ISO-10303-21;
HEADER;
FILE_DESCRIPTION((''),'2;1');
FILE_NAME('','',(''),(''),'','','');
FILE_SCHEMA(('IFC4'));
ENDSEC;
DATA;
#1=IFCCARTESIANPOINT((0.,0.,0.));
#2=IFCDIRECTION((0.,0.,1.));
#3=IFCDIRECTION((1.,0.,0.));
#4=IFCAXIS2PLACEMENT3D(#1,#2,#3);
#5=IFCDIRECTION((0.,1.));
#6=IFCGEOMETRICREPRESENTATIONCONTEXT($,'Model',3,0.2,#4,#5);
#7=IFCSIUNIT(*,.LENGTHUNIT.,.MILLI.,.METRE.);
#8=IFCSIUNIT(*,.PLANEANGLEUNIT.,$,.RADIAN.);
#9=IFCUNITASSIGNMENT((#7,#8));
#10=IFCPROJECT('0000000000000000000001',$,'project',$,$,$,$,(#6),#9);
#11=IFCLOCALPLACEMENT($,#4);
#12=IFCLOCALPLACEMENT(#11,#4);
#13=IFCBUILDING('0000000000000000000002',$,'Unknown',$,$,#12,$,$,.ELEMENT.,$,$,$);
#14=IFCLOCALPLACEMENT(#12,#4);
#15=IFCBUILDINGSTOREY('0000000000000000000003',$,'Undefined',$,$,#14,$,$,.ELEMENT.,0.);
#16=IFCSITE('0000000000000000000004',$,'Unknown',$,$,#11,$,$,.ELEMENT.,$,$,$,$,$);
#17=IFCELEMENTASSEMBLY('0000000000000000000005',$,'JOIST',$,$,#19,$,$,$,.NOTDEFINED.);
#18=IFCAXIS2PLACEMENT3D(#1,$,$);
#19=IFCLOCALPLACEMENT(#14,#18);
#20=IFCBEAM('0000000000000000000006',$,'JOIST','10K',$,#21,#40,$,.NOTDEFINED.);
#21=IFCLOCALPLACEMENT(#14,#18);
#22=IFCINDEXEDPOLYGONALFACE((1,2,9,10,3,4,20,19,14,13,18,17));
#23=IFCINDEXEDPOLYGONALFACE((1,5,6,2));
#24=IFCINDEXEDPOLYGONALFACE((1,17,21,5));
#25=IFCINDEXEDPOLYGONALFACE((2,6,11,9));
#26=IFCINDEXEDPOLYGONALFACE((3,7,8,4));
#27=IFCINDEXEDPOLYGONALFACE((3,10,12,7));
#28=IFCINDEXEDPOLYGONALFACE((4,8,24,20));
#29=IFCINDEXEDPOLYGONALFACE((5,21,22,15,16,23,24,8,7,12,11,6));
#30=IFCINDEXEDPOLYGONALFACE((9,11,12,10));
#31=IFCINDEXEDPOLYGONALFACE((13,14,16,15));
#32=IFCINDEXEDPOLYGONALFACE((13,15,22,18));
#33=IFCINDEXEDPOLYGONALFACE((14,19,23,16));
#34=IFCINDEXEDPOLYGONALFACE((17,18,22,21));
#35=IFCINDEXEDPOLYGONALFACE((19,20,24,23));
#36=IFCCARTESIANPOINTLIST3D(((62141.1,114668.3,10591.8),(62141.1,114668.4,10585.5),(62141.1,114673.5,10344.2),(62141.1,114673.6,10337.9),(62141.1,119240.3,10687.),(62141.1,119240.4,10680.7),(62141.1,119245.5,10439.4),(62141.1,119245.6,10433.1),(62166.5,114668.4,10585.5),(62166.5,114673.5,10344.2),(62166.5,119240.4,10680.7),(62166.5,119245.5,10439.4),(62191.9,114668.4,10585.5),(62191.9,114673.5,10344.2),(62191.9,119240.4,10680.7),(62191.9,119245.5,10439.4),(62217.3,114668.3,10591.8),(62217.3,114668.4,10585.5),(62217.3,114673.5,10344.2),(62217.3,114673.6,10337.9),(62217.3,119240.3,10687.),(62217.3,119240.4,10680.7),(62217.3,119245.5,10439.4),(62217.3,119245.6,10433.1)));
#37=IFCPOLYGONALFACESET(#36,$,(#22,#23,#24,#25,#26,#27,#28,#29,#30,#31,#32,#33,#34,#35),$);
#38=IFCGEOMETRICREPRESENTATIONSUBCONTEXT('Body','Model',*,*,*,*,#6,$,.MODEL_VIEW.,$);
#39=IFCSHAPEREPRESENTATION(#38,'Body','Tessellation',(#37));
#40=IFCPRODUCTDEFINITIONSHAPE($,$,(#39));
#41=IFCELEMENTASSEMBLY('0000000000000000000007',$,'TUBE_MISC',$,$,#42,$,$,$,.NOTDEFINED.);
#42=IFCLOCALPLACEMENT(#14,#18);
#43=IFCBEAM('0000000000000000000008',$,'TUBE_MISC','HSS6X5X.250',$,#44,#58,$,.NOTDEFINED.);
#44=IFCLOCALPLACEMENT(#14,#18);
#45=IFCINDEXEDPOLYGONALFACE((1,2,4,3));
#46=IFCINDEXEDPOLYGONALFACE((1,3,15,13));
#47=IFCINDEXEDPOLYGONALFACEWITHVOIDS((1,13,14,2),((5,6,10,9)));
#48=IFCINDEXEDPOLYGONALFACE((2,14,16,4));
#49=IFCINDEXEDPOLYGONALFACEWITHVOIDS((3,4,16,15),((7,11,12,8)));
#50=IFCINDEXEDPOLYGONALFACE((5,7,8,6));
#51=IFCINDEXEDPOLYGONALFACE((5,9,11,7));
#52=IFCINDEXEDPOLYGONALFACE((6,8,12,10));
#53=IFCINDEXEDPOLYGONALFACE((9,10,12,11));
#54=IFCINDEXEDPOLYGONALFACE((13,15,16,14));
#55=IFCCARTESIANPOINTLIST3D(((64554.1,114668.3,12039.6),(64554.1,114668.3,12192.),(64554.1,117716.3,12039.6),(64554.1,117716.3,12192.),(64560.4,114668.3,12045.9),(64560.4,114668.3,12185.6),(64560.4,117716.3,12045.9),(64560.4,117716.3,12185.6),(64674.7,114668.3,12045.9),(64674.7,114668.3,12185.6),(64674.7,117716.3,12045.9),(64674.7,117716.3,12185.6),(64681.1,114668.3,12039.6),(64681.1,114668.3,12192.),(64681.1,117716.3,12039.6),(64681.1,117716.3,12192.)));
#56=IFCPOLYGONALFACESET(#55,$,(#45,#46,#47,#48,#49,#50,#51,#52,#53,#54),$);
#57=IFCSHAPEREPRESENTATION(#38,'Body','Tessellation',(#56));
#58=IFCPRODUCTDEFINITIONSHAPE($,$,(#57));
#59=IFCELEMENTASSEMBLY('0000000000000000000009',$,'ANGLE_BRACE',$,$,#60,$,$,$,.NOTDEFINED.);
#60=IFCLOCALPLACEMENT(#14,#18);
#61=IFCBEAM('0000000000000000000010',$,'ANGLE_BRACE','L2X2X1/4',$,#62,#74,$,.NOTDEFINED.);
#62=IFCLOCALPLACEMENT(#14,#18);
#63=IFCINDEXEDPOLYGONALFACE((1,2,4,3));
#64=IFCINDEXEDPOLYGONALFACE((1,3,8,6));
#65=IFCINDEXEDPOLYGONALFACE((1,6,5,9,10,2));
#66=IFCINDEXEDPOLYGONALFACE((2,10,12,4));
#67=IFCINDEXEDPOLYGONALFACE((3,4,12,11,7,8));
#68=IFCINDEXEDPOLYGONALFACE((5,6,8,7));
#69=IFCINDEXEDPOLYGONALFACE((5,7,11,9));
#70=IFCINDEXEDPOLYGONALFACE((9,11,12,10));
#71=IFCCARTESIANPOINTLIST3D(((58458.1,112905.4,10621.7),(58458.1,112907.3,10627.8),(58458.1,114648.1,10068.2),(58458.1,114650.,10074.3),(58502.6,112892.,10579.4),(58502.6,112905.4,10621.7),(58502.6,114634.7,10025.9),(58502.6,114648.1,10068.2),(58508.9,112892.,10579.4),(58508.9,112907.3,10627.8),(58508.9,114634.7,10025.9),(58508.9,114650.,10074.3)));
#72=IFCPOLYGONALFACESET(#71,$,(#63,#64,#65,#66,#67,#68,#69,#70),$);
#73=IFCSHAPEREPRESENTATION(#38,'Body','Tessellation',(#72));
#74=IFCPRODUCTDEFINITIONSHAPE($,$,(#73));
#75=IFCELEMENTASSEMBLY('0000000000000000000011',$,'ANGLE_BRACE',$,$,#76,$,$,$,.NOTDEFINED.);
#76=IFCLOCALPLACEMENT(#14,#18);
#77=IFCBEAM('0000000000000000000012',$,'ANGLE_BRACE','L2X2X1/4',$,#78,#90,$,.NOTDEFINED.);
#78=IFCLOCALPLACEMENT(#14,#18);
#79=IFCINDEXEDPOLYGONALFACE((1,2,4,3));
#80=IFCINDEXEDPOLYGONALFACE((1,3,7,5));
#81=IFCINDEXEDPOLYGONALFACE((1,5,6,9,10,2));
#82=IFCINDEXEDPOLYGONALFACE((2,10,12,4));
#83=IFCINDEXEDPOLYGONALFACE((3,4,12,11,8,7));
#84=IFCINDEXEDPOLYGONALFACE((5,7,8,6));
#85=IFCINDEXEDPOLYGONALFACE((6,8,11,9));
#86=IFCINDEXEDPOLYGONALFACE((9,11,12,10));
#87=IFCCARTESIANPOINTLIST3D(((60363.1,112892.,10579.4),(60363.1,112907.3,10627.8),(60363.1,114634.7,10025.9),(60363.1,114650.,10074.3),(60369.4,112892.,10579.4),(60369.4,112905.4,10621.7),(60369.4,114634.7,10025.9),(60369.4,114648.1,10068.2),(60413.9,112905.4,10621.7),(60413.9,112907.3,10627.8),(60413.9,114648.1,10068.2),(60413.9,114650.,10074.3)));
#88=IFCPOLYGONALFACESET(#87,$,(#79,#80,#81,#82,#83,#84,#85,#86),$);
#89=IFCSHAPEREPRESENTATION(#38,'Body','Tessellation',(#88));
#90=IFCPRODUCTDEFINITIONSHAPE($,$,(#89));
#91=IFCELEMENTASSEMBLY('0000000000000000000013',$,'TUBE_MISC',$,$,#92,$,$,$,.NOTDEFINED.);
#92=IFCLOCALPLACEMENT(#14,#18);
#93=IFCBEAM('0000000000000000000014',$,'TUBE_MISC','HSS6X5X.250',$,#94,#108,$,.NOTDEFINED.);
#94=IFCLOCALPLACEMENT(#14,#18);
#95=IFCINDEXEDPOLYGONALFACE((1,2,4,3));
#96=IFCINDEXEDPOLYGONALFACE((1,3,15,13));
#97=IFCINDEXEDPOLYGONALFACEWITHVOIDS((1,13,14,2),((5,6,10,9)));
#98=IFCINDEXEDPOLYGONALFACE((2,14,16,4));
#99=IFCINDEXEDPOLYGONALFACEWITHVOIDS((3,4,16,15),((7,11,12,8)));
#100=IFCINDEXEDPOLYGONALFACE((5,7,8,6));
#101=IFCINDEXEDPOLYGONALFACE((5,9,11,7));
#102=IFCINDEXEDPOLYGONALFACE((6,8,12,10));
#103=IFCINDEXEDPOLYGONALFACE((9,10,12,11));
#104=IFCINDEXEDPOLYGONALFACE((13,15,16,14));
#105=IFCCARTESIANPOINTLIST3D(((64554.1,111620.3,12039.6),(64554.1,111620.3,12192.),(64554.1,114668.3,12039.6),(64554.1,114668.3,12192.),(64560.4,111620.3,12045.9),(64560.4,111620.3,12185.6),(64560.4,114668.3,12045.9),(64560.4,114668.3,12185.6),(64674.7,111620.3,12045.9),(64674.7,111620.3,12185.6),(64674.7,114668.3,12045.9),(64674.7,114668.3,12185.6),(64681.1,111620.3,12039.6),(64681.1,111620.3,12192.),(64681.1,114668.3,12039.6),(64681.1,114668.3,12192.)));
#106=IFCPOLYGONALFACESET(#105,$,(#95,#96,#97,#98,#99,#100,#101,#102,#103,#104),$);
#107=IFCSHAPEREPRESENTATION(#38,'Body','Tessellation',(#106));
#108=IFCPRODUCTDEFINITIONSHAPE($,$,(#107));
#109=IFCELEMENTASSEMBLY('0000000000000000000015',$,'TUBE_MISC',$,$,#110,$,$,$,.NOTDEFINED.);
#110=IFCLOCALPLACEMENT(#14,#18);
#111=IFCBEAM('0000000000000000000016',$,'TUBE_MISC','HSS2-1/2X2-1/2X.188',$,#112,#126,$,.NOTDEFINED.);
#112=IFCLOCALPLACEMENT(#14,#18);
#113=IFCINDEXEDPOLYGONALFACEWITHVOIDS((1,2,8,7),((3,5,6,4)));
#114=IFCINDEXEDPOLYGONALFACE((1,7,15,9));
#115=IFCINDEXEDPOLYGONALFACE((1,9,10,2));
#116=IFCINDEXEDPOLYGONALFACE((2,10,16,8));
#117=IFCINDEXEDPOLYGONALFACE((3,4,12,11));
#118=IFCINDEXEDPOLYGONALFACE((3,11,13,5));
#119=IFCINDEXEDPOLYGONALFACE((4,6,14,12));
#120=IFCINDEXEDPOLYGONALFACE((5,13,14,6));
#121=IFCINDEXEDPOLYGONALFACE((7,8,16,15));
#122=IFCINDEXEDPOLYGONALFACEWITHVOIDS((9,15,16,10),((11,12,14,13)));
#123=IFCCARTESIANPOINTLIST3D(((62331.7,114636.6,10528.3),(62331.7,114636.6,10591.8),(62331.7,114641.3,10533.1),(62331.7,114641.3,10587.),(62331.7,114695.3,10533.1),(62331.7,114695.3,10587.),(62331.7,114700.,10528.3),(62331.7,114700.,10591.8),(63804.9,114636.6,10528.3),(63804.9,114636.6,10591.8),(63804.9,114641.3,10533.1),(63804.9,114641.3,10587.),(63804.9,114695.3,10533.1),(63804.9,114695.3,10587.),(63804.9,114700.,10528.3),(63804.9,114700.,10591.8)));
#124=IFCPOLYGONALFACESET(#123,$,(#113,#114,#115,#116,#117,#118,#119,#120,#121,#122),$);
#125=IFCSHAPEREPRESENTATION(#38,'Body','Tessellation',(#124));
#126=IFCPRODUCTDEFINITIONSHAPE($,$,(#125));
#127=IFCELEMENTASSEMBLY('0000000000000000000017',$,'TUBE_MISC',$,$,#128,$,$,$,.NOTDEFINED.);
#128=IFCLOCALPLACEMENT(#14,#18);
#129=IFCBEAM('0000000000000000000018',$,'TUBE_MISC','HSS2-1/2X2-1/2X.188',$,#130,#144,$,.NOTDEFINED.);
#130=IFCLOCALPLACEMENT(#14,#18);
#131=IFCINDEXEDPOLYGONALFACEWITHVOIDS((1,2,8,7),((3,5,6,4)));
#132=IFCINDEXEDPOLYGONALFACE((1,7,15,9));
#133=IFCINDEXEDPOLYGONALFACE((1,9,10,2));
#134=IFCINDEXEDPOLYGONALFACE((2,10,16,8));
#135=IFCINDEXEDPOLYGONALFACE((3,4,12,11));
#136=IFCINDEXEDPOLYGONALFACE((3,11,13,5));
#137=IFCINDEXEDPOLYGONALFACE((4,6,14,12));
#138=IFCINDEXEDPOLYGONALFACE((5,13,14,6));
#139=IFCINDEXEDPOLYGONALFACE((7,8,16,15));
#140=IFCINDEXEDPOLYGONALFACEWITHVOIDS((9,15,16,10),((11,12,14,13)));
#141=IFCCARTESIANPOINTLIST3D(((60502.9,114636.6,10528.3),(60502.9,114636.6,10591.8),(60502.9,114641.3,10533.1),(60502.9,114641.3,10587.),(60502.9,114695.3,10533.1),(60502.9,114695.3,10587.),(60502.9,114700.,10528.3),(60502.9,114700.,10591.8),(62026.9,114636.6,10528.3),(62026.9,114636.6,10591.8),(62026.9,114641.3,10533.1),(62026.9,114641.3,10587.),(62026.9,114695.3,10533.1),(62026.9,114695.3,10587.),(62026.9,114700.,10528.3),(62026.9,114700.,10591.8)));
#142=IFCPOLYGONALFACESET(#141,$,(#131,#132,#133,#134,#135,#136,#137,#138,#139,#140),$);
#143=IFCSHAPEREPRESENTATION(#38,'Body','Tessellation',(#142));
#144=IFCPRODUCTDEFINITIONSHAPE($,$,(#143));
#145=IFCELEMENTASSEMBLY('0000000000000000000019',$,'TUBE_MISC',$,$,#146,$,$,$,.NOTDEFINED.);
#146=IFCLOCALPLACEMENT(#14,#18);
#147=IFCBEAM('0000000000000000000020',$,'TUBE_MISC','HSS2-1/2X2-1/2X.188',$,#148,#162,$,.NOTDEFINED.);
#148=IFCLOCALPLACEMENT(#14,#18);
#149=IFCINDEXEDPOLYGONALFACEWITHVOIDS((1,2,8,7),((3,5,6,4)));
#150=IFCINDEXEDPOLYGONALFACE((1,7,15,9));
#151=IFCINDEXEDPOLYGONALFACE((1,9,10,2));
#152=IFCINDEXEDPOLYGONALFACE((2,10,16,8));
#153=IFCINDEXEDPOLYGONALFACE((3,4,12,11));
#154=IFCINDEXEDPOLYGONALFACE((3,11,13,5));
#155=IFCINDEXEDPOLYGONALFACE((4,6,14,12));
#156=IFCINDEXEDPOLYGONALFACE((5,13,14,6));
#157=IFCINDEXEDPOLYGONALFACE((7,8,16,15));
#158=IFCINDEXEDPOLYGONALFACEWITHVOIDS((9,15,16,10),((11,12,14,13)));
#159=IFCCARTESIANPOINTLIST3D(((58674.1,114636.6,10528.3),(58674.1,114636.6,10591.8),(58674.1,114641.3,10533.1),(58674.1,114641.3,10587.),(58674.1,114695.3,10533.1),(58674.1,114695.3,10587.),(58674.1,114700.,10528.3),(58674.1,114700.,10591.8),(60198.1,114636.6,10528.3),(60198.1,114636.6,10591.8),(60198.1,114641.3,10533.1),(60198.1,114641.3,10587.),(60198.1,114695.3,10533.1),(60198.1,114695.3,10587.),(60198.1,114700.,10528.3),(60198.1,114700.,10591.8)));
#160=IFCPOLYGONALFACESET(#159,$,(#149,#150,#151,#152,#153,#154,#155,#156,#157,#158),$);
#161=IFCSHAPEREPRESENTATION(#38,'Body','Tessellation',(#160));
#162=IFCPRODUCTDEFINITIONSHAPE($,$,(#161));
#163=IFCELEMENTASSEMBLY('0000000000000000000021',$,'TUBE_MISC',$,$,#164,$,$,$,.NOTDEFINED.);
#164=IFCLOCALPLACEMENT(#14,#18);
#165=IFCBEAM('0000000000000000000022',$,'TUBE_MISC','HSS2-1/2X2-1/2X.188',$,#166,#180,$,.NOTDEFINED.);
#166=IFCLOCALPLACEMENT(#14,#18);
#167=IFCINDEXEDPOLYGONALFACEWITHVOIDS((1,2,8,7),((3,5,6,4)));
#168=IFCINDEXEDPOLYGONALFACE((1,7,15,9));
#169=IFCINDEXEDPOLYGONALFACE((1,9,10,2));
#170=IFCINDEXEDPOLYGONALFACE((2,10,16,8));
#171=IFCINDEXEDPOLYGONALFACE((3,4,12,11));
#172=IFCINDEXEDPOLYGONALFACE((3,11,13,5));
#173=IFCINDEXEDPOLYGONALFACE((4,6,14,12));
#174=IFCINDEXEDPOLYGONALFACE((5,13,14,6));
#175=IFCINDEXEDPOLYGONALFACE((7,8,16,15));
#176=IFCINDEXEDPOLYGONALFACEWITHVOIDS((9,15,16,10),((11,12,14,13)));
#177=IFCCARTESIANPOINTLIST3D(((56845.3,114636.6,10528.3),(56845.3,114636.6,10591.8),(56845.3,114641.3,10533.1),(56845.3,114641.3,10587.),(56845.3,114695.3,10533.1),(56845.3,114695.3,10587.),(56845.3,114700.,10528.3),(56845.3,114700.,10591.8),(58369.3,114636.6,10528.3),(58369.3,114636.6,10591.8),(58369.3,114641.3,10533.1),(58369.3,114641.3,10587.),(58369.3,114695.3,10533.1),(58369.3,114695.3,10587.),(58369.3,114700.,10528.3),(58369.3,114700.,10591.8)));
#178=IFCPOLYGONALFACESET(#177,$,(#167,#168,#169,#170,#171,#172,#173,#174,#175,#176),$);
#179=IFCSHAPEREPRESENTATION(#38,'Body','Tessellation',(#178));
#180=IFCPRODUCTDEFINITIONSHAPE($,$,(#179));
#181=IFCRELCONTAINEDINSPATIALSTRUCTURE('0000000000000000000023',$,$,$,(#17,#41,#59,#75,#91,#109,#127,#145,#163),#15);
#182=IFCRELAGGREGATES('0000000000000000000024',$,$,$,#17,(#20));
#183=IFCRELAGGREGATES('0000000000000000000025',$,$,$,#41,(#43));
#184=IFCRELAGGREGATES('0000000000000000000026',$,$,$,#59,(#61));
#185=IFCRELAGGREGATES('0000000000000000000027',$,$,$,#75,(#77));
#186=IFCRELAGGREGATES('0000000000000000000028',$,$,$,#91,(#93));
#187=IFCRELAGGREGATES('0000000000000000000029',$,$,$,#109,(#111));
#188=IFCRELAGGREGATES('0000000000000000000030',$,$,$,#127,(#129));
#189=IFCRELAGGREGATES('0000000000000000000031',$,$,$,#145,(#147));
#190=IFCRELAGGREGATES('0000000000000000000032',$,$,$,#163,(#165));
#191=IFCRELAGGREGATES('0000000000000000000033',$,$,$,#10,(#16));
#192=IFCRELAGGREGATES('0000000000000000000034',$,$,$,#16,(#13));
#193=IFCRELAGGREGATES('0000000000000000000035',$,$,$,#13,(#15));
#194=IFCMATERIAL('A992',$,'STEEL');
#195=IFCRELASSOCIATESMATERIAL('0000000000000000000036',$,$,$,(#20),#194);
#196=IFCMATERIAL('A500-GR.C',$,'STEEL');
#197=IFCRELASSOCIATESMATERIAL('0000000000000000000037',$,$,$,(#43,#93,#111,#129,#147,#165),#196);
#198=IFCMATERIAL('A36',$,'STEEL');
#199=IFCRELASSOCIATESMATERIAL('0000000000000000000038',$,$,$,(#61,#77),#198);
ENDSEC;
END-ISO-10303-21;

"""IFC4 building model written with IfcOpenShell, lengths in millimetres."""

from ifc_helpers import new_model, si_unit, direction, frame, origin_with_axes, place, context, subcontext, project, spatial, line, indexed_curve, outline, extrude, material, element, aggregate, save


model = new_model("IFC4")

# Units and contexts
model_context = context("Model", 3, precision=0.2, world=origin_with_axes(), true_north=direction((0.0, 1.0)))
body_context = subcontext(model_context, "Body", "Model", "MODEL_VIEW")
ifc_project = project(units=[si_unit("LENGTHUNIT", "METRE", prefix="MILLI"), si_unit("PLANEANGLEUNIT", "RADIAN")], contexts=[model_context])

# Site, building, storey
site_placement = place(None, origin_with_axes())
site = spatial("IfcSite", under=ifc_project, at=site_placement, Name="Unknown", CompositionType="ELEMENT")
building_placement = place(site_placement, origin_with_axes())
building = spatial("IfcBuilding", under=site, at=building_placement, Name="Unknown", CompositionType="ELEMENT")
storey_placement = place(building_placement, origin_with_axes())
storey = spatial("IfcBuildingStorey", under=building, at=storey_placement, Name="Undefined", CompositionType="ELEMENT", Elevation=0.0)

# Shared definitions
ifc_material_1 = material(Name="A500-GR.C", Category="STEEL")

# Element assemblies, beams
ifc_material_2 = material(Name="A992", Category="STEEL")
assembly_1_placement = place(storey_placement, frame((62179.2, 114670.9, 10464.8), z_axis=(1.0, 0.0, 0.0), x_axis=(0.0, 0.999783, 0.020819)))
assembly_1 = element("IfcElementAssembly", 1, at=assembly_1_placement, inside=storey, Name="JOIST", PredefinedType="NOTDEFINED")
beam_1_placement = place(assembly_1_placement, origin_with_axes())
beam_1 = element("IfcBeam", 2, at=beam_1_placement, material=ifc_material_2, Name="JOIST", Description="10K", PredefinedType="NOTDEFINED", context=body_context, shape_type="SolidModel", body=[
    extrude(outline(indexed_curve([(-38.1, -127.0), (38.1, -127.0), (38.1, -120.7), (12.7, -120.7), (12.7, 120.7), (38.1, 120.7), (38.1, 127.0), (-38.1, 127.0), (-38.1, 120.7), (-12.7, 120.7), (-12.7, -120.7), (-38.1, -120.7)], segments=[line(1, 2, 3, 4, 5, 6, 7, 8, 9, 10, 11, 12, 1)])), frame((0.0, 0.0, 0.0), z_axis=(-1.0, 0.0, 0.0), x_axis=(0.0, 0.0, 1.0)), (0.0, 0.0, -1.0), 4573.0),
])
aggregate(assembly_1, [beam_1])
assembly_2_placement = place(storey_placement, frame((64617.6, 114668.3, 12115.8), z_axis=(1.0, 0.0, 0.0), x_axis=(0.0, 1.0, 0.0)))
assembly_2 = element("IfcElementAssembly", 3, at=assembly_2_placement, inside=storey, Name="TUBE_MISC", PredefinedType="NOTDEFINED")
beam_2_placement = place(assembly_2_placement, origin_with_axes())
beam_2 = element("IfcBeam", 4, at=beam_2_placement, material=ifc_material_1, Name="TUBE_MISC", Description="HSS6X5X.250", PredefinedType="NOTDEFINED", context=body_context, shape_type="SolidModel", body=[
    extrude(outline(indexed_curve([(-63.5, -76.2), (63.5, -76.2), (63.5, 76.2), (-63.5, 76.2)], segments=[line(1, 2, 3, 4, 1)]), holes=[indexed_curve([(-57.1, -69.8), (-57.1, 69.8), (57.1, 69.8), (57.1, -69.8)], segments=[line(1, 2, 3, 4, 1)])]), frame((0.0, 0.0, 0.0), z_axis=(-1.0, 0.0, 0.0), x_axis=(0.0, 0.0, 1.0)), (0.0, 0.0, -1.0), 3048.0),
])
aggregate(assembly_2, [beam_2])
assembly_3_placement = place(storey_placement, frame((58483.5, 114642.4, 10050.1), z_axis=(0.0, -0.30272, -0.953079), x_axis=(0.0, -0.953079, 0.30272)))
assembly_3 = element("IfcElementAssembly", 5, at=assembly_3_placement, inside=storey, Name="ANGLE_BRACE", PredefinedType="NOTDEFINED")
ifc_material_3 = material(Name="A36", Category="STEEL")
beam_3_placement = place(assembly_3_placement, origin_with_axes())
beam_3 = element("IfcBeam", 6, at=beam_3_placement, material=ifc_material_3, Name="ANGLE_BRACE", Description="L2X2X1/4", PredefinedType="NOTDEFINED", context=body_context, shape_type="SolidModel", body=[
    extrude(outline(indexed_curve([(-25.4, -25.4), (25.4, -25.4), (25.4, -19.1), (-19.1, -19.1), (-19.1, 25.4), (-25.4, 25.4)], segments=[line(1, 2, 3, 4, 5, 6, 1)])), frame((0.0, 0.0, 0.0), z_axis=(-1.0, 0.0, 0.0), x_axis=(0.0, 0.0, 1.0)), (0.0, 0.0, -1.0), 1828.5),
])
aggregate(assembly_3, [beam_3])
assembly_4_placement = place(storey_placement, frame((60388.5, 114642.4, 10050.1), z_axis=(1.0, 0.0, 0.0), x_axis=(0.0, -0.953079, 0.30272)))
assembly_4 = element("IfcElementAssembly", 7, at=assembly_4_placement, inside=storey, Name="ANGLE_BRACE", PredefinedType="NOTDEFINED")
beam_4_placement = place(assembly_4_placement, origin_with_axes())
beam_4 = element("IfcBeam", 8, at=beam_4_placement, material=ifc_material_3, Name="ANGLE_BRACE", Description="L2X2X1/4", PredefinedType="NOTDEFINED", context=body_context, shape_type="SolidModel", body=[
    extrude(outline(indexed_curve([(-25.4, -25.4), (25.4, -25.4), (25.4, -19.1), (-19.1, -19.1), (-19.1, 25.4), (-25.4, 25.4)], segments=[line(1, 2, 3, 4, 5, 6, 1)])), frame((0.0, 0.0, 0.0), z_axis=(-1.0, 0.0, 0.0), x_axis=(0.0, 0.0, 1.0)), (0.0, 0.0, -1.0), 1828.5),
])
aggregate(assembly_4, [beam_4])
assembly_5_placement = place(storey_placement, frame((64617.6, 111620.3, 12115.8), z_axis=(1.0, 0.0, 0.0), x_axis=(0.0, 1.0, 0.0)))
assembly_5 = element("IfcElementAssembly", 9, at=assembly_5_placement, inside=storey, Name="TUBE_MISC", PredefinedType="NOTDEFINED")
beam_5_placement = place(assembly_5_placement, origin_with_axes())
beam_5 = element("IfcBeam", 10, at=beam_5_placement, material=ifc_material_1, Name="TUBE_MISC", Description="HSS6X5X.250", PredefinedType="NOTDEFINED", context=body_context, shape_type="SolidModel", body=[
    extrude(outline(indexed_curve([(-63.5, -76.2), (63.5, -76.2), (63.5, 76.2), (-63.5, 76.2)], segments=[line(1, 2, 3, 4, 1)]), holes=[indexed_curve([(-57.1, -69.8), (-57.1, 69.8), (57.1, 69.8), (57.1, -69.8)], segments=[line(1, 2, 3, 4, 1)])]), frame((0.0, 0.0, 0.0), z_axis=(-1.0, 0.0, 0.0), x_axis=(0.0, 0.0, 1.0)), (0.0, 0.0, -1.0), 3048.0),
])
aggregate(assembly_5, [beam_5])

# Element assemblies, beams
assembly_6_placement = place(storey_placement, frame((62331.7, 114668.3, 10560.0), z_axis=(0.0, -1.0, 0.0), x_axis=(1.0, 0.0, 0.0)))
assembly_6 = element("IfcElementAssembly", 11, at=assembly_6_placement, inside=storey, Name="TUBE_MISC", PredefinedType="NOTDEFINED")
beam_6_placement = place(assembly_6_placement, origin_with_axes())
beam_6 = element("IfcBeam", 12, at=beam_6_placement, material=ifc_material_1, Name="TUBE_MISC", Description="HSS2-1/2X2-1/2X.188", PredefinedType="NOTDEFINED", context=body_context, shape_type="SolidModel", body=[
    extrude(outline(indexed_curve([(-31.8, -31.8), (31.8, -31.8), (31.8, 31.8), (-31.8, 31.8)], segments=[line(1, 2, 3, 4, 1)]), holes=[indexed_curve([(-27.0, -27.0), (-27.0, 27.0), (27.0, 27.0), (27.0, -27.0)], segments=[line(1, 2, 3, 4, 1)])]), frame((0.0, 0.0, 0.0), z_axis=(-1.0, 0.0, 0.0), x_axis=(0.0, 0.0, 1.0)), (0.0, 0.0, -1.0), 1473.2),
])
aggregate(assembly_6, [beam_6])
assembly_7_placement = place(storey_placement, frame((60502.9, 114668.3, 10560.0), z_axis=(0.0, -1.0, 0.0), x_axis=(1.0, 0.0, 0.0)))
assembly_7 = element("IfcElementAssembly", 13, at=assembly_7_placement, inside=storey, Name="TUBE_MISC", PredefinedType="NOTDEFINED")
beam_7_placement = place(assembly_7_placement, origin_with_axes())
beam_7 = element("IfcBeam", 14, at=beam_7_placement, material=ifc_material_1, Name="TUBE_MISC", Description="HSS2-1/2X2-1/2X.188", PredefinedType="NOTDEFINED", context=body_context, shape_type="SolidModel", body=[
    extrude(outline(indexed_curve([(-31.8, -31.8), (31.8, -31.8), (31.8, 31.8), (-31.8, 31.8)], segments=[line(1, 2, 3, 4, 1)]), holes=[indexed_curve([(-27.0, -27.0), (-27.0, 27.0), (27.0, 27.0), (27.0, -27.0)], segments=[line(1, 2, 3, 4, 1)])]), frame((0.0, 0.0, 0.0), z_axis=(-1.0, 0.0, 0.0), x_axis=(0.0, 0.0, 1.0)), (0.0, 0.0, -1.0), 1524.0),
])
aggregate(assembly_7, [beam_7])
assembly_8_placement = place(storey_placement, frame((58674.1, 114668.3, 10560.0), z_axis=(0.0, -1.0, 0.0), x_axis=(1.0, 0.0, 0.0)))
assembly_8 = element("IfcElementAssembly", 15, at=assembly_8_placement, inside=storey, Name="TUBE_MISC", PredefinedType="NOTDEFINED")
beam_8_placement = place(assembly_8_placement, origin_with_axes())
beam_8 = element("IfcBeam", 16, at=beam_8_placement, material=ifc_material_1, Name="TUBE_MISC", Description="HSS2-1/2X2-1/2X.188", PredefinedType="NOTDEFINED", context=body_context, shape_type="SolidModel", body=[
    extrude(outline(indexed_curve([(-31.8, -31.8), (31.8, -31.8), (31.8, 31.8), (-31.8, 31.8)], segments=[line(1, 2, 3, 4, 1)]), holes=[indexed_curve([(-27.0, -27.0), (-27.0, 27.0), (27.0, 27.0), (27.0, -27.0)], segments=[line(1, 2, 3, 4, 1)])]), frame((0.0, 0.0, 0.0), z_axis=(-1.0, 0.0, 0.0), x_axis=(0.0, 0.0, 1.0)), (0.0, 0.0, -1.0), 1524.0),
])
aggregate(assembly_8, [beam_8])
assembly_9_placement = place(storey_placement, frame((56845.3, 114668.3, 10560.0), z_axis=(0.0, -1.0, 0.0), x_axis=(1.0, 0.0, 0.0)))
assembly_9 = element("IfcElementAssembly", 17, at=assembly_9_placement, inside=storey, Name="TUBE_MISC", PredefinedType="NOTDEFINED")
beam_9_placement = place(assembly_9_placement, origin_with_axes())
beam_9 = element("IfcBeam", 18, at=beam_9_placement, material=ifc_material_1, Name="TUBE_MISC", Description="HSS2-1/2X2-1/2X.188", PredefinedType="NOTDEFINED", context=body_context, shape_type="SolidModel", body=[
    extrude(outline(indexed_curve([(-31.8, -31.8), (31.8, -31.8), (31.8, 31.8), (-31.8, 31.8)], segments=[line(1, 2, 3, 4, 1)]), holes=[indexed_curve([(-27.0, -27.0), (-27.0, 27.0), (27.0, 27.0), (27.0, -27.0)], segments=[line(1, 2, 3, 4, 1)])]), frame((0.0, 0.0, 0.0), z_axis=(-1.0, 0.0, 0.0), x_axis=(0.0, 0.0, 1.0)), (0.0, 0.0, -1.0), 1524.0),
])
aggregate(assembly_9, [beam_9])

save(model, "model.ifc")
